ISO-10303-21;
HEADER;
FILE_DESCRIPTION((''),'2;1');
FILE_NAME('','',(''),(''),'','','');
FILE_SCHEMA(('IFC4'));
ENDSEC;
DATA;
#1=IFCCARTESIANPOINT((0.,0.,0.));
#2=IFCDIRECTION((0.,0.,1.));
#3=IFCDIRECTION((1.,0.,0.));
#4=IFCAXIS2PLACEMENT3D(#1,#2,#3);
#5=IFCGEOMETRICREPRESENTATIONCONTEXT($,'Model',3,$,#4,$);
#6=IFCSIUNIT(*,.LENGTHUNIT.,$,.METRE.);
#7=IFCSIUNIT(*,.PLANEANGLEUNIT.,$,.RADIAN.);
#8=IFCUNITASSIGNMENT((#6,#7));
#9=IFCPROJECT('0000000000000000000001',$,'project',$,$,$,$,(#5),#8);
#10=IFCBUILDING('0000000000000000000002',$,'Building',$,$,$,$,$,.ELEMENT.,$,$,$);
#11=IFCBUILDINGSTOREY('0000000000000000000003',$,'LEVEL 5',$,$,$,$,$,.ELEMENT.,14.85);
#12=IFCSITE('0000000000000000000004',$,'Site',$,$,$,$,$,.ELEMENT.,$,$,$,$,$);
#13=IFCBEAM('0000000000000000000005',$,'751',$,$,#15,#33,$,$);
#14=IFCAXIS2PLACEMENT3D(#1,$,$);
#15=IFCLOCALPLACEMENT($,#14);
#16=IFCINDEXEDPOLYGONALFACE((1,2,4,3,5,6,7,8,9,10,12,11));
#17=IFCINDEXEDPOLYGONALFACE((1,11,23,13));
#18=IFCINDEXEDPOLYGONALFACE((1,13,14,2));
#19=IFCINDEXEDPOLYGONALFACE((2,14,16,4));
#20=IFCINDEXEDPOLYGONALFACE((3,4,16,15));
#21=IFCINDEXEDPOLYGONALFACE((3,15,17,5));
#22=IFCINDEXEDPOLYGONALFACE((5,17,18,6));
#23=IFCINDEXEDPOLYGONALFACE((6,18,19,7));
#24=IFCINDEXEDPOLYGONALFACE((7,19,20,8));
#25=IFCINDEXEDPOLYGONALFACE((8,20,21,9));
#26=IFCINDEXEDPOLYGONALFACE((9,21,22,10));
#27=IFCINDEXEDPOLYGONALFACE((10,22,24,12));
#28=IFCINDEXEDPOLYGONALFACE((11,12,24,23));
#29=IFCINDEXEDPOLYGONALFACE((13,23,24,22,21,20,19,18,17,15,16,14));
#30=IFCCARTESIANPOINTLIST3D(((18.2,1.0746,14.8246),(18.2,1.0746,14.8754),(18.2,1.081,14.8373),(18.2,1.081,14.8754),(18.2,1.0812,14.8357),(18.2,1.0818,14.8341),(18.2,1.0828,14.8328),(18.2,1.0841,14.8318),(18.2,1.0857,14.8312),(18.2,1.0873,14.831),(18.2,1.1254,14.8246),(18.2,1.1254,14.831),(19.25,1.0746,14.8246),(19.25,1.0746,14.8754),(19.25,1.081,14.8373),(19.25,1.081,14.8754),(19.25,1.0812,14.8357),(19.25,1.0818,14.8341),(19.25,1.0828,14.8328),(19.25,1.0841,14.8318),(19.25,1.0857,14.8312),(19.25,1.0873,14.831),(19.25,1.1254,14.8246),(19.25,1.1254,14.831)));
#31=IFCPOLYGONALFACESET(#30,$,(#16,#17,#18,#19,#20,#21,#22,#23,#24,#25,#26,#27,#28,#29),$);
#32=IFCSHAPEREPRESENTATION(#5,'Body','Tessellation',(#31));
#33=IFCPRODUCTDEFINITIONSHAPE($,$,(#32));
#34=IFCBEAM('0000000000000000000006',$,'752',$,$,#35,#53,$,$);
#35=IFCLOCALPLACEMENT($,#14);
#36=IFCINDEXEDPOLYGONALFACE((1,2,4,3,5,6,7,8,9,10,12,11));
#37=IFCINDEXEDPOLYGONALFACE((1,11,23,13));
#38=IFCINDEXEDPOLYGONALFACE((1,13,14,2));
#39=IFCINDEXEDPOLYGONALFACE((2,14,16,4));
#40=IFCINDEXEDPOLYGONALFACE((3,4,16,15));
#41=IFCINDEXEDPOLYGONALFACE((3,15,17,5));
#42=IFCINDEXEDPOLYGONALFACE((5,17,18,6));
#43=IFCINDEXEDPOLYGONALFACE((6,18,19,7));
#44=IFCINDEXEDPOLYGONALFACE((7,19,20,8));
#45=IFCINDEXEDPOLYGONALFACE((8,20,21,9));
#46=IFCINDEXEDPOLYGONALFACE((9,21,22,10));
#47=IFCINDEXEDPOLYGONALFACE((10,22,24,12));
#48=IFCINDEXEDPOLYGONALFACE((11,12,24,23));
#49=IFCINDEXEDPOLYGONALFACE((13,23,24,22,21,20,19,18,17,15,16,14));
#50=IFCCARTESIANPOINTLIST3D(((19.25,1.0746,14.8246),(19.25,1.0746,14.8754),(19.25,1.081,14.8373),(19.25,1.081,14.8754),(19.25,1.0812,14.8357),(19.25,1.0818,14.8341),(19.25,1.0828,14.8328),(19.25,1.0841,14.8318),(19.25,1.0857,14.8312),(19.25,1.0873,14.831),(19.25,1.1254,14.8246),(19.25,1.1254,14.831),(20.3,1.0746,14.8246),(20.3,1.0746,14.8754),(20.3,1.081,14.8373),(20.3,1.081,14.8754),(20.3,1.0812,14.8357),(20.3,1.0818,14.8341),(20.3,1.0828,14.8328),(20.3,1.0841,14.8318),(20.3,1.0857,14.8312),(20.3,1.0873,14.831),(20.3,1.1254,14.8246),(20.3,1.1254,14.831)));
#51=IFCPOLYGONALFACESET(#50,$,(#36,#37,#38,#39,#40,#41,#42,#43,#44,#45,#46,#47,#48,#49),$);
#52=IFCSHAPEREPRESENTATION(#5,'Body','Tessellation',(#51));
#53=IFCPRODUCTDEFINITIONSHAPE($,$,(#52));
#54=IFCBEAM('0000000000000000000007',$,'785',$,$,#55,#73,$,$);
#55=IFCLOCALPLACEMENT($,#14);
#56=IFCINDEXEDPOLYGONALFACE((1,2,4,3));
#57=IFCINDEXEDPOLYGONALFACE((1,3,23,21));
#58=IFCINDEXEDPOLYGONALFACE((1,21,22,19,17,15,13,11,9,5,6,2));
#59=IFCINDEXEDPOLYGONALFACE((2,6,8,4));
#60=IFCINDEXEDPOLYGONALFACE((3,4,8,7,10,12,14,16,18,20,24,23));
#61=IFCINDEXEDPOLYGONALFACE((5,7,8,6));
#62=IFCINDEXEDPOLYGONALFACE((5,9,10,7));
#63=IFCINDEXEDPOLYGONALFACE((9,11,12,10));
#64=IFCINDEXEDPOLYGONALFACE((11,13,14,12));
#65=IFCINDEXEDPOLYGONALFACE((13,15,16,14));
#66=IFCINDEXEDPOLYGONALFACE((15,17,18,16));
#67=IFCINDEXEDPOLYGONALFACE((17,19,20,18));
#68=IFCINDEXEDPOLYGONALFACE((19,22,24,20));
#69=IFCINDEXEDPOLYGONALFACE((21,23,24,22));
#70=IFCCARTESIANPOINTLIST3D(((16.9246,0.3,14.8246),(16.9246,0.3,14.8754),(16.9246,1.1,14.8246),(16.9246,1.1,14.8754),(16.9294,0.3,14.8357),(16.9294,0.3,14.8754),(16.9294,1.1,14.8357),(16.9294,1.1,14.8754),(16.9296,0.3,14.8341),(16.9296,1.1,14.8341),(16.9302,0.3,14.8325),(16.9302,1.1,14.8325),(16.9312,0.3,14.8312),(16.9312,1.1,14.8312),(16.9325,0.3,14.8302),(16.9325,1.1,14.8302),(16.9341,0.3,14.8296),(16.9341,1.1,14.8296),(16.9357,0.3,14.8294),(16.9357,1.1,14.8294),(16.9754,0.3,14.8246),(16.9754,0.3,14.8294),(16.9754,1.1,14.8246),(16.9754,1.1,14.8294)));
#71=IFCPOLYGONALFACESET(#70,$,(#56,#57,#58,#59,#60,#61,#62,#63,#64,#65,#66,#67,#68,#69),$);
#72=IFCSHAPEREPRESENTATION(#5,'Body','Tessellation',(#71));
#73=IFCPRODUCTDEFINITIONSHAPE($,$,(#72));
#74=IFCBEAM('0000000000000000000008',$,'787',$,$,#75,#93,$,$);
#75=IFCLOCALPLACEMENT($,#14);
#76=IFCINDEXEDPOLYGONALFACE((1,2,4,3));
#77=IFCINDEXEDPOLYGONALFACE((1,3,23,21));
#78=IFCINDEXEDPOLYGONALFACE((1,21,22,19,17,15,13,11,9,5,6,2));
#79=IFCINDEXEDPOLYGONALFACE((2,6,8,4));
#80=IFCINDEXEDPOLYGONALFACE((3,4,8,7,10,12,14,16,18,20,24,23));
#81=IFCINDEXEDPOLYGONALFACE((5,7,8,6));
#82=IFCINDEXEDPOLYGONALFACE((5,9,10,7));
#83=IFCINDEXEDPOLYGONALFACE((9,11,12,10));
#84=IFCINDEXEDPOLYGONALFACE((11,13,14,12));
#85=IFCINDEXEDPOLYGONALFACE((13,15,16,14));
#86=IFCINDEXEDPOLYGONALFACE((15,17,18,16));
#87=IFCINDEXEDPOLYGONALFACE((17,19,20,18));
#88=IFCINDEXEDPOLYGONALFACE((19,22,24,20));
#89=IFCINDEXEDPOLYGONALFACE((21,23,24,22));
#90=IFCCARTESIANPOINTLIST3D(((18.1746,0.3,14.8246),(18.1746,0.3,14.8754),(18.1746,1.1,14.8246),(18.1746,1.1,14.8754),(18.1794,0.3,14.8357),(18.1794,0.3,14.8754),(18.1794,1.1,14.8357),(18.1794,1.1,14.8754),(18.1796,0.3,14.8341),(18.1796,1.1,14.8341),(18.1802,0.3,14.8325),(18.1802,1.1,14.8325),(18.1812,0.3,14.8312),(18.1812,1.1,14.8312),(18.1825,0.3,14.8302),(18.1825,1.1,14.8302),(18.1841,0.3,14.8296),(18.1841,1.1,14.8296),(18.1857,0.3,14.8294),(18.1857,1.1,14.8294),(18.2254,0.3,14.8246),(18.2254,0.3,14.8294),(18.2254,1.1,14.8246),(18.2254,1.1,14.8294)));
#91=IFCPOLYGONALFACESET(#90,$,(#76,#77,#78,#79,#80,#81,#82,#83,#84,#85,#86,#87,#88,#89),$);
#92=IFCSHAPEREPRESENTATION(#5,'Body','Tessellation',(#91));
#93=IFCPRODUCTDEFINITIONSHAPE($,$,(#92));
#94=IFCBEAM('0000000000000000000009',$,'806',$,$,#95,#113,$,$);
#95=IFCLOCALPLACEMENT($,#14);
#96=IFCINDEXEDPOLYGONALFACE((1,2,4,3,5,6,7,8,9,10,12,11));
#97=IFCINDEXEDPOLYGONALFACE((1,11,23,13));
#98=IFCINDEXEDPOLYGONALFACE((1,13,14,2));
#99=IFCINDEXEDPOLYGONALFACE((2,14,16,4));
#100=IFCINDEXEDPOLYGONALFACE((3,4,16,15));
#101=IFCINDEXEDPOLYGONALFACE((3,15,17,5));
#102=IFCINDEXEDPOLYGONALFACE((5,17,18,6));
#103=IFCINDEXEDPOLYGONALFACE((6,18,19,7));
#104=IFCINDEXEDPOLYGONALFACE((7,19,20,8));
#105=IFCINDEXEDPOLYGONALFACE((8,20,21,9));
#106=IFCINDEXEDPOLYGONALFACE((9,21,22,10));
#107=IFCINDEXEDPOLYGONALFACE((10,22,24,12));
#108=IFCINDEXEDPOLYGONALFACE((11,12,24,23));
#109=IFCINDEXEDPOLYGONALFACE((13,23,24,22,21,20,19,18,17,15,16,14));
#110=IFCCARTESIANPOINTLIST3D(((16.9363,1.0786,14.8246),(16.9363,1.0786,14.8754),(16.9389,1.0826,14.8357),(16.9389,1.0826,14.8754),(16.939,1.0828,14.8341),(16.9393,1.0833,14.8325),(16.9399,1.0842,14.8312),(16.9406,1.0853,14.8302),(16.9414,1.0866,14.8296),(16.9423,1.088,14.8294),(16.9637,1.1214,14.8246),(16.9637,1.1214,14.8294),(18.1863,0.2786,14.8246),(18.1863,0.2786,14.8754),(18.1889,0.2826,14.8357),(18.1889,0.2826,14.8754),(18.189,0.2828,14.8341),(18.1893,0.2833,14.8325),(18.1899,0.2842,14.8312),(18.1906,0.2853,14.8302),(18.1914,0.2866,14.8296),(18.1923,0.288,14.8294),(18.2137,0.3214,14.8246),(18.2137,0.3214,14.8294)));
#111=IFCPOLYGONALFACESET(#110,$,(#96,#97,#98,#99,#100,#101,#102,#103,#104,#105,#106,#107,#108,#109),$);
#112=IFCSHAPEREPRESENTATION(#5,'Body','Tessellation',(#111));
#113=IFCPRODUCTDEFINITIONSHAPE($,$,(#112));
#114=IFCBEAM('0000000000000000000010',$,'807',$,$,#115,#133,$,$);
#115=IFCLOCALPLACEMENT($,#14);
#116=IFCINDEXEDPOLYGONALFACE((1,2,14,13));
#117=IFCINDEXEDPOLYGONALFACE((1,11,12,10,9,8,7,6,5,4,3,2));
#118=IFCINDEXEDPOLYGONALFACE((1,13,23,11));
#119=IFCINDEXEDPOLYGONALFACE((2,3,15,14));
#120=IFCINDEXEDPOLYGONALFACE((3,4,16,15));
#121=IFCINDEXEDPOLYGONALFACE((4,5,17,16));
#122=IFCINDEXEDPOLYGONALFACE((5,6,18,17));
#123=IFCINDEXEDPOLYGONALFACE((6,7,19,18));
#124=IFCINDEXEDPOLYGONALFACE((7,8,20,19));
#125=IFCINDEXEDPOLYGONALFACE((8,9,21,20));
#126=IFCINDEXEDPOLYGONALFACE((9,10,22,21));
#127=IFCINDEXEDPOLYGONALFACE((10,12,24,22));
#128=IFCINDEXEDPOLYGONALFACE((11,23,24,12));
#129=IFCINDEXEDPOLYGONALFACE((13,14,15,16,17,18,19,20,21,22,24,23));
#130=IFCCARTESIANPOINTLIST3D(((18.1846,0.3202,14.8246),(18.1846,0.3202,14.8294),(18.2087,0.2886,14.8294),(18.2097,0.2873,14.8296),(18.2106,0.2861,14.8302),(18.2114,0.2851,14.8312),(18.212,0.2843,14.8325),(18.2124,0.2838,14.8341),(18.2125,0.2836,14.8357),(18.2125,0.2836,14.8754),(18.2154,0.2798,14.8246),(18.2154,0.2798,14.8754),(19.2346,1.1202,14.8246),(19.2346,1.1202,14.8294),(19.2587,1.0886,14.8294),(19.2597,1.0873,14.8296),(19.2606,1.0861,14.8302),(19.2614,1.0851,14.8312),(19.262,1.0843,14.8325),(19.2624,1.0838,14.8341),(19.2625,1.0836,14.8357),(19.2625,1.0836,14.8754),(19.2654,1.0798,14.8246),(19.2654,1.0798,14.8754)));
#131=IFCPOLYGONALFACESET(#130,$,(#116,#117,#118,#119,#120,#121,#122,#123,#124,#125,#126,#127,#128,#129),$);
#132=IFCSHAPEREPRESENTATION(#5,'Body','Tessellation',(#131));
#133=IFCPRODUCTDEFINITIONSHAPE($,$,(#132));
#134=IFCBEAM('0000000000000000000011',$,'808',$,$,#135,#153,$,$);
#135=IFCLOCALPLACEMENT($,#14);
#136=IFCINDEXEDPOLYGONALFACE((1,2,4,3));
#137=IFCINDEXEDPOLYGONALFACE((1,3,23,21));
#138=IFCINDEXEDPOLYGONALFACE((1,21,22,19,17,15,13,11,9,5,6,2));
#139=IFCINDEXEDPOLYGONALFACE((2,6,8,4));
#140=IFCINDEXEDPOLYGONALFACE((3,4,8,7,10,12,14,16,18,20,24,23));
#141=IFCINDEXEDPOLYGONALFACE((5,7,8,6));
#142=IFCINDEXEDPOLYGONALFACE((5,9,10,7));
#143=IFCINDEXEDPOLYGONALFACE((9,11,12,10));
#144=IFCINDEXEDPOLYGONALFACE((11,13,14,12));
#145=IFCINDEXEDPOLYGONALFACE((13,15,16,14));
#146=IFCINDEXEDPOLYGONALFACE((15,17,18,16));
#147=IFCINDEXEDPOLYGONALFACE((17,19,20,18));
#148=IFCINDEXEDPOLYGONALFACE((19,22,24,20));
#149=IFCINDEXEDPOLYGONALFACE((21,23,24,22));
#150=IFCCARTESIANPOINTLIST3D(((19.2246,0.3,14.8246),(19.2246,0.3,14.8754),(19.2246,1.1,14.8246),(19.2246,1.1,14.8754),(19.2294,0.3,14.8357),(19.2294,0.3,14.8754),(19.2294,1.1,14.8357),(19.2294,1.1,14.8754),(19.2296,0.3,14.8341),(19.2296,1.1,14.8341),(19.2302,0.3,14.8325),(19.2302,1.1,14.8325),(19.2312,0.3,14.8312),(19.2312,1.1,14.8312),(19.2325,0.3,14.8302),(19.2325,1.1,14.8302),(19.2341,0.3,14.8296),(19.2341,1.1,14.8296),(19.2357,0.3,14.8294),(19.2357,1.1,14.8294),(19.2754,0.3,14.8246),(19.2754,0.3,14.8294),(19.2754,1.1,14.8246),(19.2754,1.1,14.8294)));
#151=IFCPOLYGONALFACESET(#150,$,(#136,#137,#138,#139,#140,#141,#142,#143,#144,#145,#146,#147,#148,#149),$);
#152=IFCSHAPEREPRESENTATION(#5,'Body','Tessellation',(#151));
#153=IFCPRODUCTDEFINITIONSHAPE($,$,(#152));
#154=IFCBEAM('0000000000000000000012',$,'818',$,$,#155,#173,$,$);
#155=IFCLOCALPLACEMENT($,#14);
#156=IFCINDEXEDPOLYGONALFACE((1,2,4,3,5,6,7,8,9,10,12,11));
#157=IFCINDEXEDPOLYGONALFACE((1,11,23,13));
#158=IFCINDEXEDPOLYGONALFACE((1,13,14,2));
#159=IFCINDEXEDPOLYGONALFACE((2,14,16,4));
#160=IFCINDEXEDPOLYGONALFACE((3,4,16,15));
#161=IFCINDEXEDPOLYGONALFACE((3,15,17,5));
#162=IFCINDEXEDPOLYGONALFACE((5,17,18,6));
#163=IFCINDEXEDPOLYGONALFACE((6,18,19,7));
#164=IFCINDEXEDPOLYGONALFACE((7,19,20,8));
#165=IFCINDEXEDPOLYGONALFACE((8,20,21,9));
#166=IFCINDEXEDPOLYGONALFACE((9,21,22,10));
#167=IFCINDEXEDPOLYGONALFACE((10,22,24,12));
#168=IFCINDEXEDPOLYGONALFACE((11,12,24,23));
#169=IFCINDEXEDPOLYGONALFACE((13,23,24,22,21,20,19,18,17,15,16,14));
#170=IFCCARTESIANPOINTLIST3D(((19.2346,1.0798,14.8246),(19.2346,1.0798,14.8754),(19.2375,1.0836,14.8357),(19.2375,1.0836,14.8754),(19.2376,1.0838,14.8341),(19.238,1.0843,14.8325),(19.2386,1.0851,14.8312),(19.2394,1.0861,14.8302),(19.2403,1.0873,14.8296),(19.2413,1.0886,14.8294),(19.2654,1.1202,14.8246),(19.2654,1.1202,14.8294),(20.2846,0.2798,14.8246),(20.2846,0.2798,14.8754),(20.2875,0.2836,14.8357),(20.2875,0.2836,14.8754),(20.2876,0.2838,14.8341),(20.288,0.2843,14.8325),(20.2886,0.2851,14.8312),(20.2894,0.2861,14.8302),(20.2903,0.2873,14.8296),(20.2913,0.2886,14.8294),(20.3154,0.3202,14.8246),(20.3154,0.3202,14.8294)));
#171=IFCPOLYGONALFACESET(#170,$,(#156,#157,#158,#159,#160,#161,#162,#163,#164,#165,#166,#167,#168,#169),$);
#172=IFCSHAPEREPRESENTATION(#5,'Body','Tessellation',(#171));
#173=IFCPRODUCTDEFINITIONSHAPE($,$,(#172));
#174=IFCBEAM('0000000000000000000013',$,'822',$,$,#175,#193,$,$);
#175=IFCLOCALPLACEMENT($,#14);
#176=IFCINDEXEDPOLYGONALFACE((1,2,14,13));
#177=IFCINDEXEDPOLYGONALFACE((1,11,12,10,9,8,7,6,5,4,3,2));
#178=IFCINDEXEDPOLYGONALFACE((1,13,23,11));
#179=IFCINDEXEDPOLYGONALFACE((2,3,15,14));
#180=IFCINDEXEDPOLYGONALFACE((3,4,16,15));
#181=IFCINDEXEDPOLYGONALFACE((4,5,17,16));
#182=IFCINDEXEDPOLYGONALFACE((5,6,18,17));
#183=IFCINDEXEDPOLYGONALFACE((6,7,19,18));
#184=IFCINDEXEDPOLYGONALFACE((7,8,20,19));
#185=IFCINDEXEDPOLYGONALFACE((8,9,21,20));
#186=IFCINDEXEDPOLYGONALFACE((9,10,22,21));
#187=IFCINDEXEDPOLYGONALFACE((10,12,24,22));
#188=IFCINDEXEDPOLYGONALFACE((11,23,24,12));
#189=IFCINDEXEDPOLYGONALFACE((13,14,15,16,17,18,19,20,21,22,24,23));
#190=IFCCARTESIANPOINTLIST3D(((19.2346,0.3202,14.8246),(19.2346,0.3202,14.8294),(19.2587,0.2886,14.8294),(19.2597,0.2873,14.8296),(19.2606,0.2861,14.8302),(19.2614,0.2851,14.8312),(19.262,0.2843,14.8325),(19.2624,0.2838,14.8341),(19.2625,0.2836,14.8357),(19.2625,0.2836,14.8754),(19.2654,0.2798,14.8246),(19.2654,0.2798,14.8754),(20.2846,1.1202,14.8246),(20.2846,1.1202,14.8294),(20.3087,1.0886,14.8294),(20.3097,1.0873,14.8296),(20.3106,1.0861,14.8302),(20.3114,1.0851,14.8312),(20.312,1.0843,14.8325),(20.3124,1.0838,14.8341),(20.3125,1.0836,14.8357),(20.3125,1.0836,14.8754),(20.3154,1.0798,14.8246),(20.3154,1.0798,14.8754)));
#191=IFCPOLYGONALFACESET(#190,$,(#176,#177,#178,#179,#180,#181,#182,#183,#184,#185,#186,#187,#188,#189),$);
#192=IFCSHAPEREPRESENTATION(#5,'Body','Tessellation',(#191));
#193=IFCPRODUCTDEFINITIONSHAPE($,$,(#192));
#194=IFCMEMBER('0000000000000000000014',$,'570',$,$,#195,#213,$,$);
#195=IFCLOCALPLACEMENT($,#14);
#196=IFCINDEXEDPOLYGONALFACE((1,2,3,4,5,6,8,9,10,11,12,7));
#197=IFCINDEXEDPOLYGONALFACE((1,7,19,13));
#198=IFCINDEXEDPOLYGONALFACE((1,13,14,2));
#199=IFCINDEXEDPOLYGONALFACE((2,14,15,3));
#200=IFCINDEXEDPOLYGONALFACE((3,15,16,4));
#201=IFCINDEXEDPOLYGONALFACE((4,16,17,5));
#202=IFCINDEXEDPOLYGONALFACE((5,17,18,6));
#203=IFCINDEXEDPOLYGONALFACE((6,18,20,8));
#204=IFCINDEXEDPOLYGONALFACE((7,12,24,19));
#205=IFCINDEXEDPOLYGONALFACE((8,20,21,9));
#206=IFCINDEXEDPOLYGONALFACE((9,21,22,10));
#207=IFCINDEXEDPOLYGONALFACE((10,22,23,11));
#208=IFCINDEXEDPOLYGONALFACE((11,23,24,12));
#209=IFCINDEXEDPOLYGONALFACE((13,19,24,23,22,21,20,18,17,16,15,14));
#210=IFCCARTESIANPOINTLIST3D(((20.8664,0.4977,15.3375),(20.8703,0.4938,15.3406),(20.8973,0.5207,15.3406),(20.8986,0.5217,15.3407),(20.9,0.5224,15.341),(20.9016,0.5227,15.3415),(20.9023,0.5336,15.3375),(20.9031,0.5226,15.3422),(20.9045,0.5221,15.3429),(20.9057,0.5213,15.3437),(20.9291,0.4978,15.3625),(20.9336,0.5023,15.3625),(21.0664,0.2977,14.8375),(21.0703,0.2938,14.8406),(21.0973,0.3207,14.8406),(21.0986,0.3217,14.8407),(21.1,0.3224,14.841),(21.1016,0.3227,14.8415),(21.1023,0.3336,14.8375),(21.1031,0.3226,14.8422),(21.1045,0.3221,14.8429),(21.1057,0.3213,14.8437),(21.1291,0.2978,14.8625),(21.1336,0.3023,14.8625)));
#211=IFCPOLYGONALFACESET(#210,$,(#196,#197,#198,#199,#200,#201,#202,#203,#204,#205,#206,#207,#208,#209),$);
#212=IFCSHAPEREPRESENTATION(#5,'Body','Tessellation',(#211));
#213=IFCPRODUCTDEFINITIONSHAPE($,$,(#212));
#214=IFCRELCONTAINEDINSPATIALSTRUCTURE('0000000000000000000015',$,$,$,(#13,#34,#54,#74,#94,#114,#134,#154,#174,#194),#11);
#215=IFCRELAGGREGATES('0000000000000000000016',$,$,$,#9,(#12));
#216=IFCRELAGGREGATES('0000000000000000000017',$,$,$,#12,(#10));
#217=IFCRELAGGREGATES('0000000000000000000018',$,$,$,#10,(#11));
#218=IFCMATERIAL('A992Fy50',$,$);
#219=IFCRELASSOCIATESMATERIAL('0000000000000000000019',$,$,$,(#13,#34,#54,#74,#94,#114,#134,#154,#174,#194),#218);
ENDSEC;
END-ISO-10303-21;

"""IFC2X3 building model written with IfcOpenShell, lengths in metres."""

from ifc_helpers import new_model, si_unit, frame, origin_with_axes, origin_2d_with_axis, place, context, project, spatial, l_section, extrude, material, element, save


model = new_model("IFC2X3")

# Units and contexts
model_context = context("Model", 3, world=origin_with_axes())
ifc_project = project(units=[si_unit("LENGTHUNIT", "METRE"), si_unit("PLANEANGLEUNIT", "RADIAN")], contexts=[model_context])

# Site, building, storey
site = spatial("IfcSite", under=ifc_project, Name="Site", CompositionType="ELEMENT")
building = spatial("IfcBuilding", under=site, Name="Building", CompositionType="ELEMENT")
storey = spatial("IfcBuildingStorey", under=building, Name="LEVEL 5", CompositionType="ELEMENT", Elevation=14.85)

# Beams
ifc_material = material(Name="A992Fy50")
for number, where, z_axis, x_axis, name in (
    (1, (18.2, 1.1, 14.85), (1.0, 0.0, 0.0), (0.0, 1.0, 0.0), "751"),
    (2, (19.25, 1.1, 14.85), (1.0, 0.0, 0.0), (0.0, 1.0, 0.0), "752"),
):
    element("IfcBeam", number, at=place(None, frame(where, z_axis=z_axis, x_axis=x_axis)), inside=storey, material=ifc_material, Name=name, context=model_context, shape_type="SweptSolid", body=[
        extrude(l_section(Depth=0.0508, Width=0.0508, Thickness=0.0063, FilletRadius=0.0063, at=origin_2d_with_axis()), origin_with_axes(), (0.0, 0.0, 1.0), 1.05),
    ])
for number, where, z_axis, x_axis, name in (
    (3, (16.95, 1.1, 14.85), (0.0, -1.0, 0.0), (1.0, 0.0, 0.0), "785"),
    (4, (18.2, 1.1, 14.85), (0.0, -1.0, 0.0), (1.0, 0.0, 0.0), "787"),
):
    element("IfcBeam", number, at=place(None, frame(where, z_axis=z_axis, x_axis=x_axis)), inside=storey, material=ifc_material, Name=name, context=model_context, shape_type="SweptSolid", body=[
        extrude(l_section(Depth=0.0508, Width=0.0508, Thickness=0.0048, FilletRadius=0.0063, at=origin_2d_with_axis()), origin_with_axes(), (0.0, 0.0, 1.0), 0.8),
    ])
beam_1_placement = place(None, frame((16.95, 1.1, 14.85), z_axis=(0.842271, -0.539054, 0.0), x_axis=(0.539054, 0.842271, 0.0)))
element("IfcBeam", 5, at=beam_1_placement, inside=storey, material=ifc_material, Name="806", context=model_context, shape_type="SweptSolid", body=[
    extrude(l_section(Depth=0.0508, Width=0.0508, Thickness=0.0048, FilletRadius=0.0063, at=origin_2d_with_axis()), origin_with_axes(), (0.0, 0.0, 1.0), 1.4841),
])
beam_2_placement = place(None, frame((18.2, 0.3, 14.85), z_axis=(0.795432, 0.606043, 0.0), x_axis=(-0.606043, 0.795432, 0.0)))
element("IfcBeam", 6, at=beam_2_placement, inside=storey, material=ifc_material, Name="807", context=model_context, shape_type="SweptSolid", body=[
    extrude(l_section(Depth=0.0508, Width=0.0508, Thickness=0.0048, FilletRadius=0.0063, at=origin_2d_with_axis()), origin_with_axes(), (0.0, 0.0, 1.0), 1.32),
])
beam_3_placement = place(None, frame((19.25, 1.1, 14.85), z_axis=(0.0, -1.0, 0.0), x_axis=(1.0, 0.0, 0.0)))
element("IfcBeam", 7, at=beam_3_placement, inside=storey, material=ifc_material, Name="808", context=model_context, shape_type="SweptSolid", body=[
    extrude(l_section(Depth=0.0508, Width=0.0508, Thickness=0.0048, FilletRadius=0.0063, at=origin_2d_with_axis()), origin_with_axes(), (0.0, 0.0, 1.0), 0.8),
])
for number, where, z_axis, x_axis, name in (
    (8, (19.25, 1.1, 14.85), (0.795432, -0.606043, 0.0), (0.606043, 0.795432, 0.0), "818"),
    (9, (19.25, 0.3, 14.85), (0.795432, 0.606043, 0.0), (-0.606043, 0.795432, 0.0), "822"),
):
    element("IfcBeam", number, at=place(None, frame(where, z_axis=z_axis, x_axis=x_axis)), inside=storey, material=ifc_material, Name=name, context=model_context, shape_type="SweptSolid", body=[
        extrude(l_section(Depth=0.0508, Width=0.0508, Thickness=0.0048, FilletRadius=0.0063, at=origin_2d_with_axis()), origin_with_axes(), (0.0, 0.0, 1.0), 1.32),
    ])

# Member
for number, where, z_axis, x_axis, name in (
    (10, (21.1, 0.3, 14.85), (-0.348155, 0.348155, 0.870388), (-0.707107, -0.707107, 0.0), "570"),
):
    element("IfcMember", number, at=place(None, frame(where, z_axis=z_axis, x_axis=x_axis)), inside=storey, material=ifc_material, Name=name, context=model_context, shape_type="SweptSolid", body=[
        extrude(l_section(Depth=0.0508, Width=0.0508, Thickness=0.0063, FilletRadius=0.0063, at=origin_2d_with_axis()), origin_with_axes(), (0.0, 0.0, 1.0), 0.5745),
    ])

save(model, "model.ifc")
